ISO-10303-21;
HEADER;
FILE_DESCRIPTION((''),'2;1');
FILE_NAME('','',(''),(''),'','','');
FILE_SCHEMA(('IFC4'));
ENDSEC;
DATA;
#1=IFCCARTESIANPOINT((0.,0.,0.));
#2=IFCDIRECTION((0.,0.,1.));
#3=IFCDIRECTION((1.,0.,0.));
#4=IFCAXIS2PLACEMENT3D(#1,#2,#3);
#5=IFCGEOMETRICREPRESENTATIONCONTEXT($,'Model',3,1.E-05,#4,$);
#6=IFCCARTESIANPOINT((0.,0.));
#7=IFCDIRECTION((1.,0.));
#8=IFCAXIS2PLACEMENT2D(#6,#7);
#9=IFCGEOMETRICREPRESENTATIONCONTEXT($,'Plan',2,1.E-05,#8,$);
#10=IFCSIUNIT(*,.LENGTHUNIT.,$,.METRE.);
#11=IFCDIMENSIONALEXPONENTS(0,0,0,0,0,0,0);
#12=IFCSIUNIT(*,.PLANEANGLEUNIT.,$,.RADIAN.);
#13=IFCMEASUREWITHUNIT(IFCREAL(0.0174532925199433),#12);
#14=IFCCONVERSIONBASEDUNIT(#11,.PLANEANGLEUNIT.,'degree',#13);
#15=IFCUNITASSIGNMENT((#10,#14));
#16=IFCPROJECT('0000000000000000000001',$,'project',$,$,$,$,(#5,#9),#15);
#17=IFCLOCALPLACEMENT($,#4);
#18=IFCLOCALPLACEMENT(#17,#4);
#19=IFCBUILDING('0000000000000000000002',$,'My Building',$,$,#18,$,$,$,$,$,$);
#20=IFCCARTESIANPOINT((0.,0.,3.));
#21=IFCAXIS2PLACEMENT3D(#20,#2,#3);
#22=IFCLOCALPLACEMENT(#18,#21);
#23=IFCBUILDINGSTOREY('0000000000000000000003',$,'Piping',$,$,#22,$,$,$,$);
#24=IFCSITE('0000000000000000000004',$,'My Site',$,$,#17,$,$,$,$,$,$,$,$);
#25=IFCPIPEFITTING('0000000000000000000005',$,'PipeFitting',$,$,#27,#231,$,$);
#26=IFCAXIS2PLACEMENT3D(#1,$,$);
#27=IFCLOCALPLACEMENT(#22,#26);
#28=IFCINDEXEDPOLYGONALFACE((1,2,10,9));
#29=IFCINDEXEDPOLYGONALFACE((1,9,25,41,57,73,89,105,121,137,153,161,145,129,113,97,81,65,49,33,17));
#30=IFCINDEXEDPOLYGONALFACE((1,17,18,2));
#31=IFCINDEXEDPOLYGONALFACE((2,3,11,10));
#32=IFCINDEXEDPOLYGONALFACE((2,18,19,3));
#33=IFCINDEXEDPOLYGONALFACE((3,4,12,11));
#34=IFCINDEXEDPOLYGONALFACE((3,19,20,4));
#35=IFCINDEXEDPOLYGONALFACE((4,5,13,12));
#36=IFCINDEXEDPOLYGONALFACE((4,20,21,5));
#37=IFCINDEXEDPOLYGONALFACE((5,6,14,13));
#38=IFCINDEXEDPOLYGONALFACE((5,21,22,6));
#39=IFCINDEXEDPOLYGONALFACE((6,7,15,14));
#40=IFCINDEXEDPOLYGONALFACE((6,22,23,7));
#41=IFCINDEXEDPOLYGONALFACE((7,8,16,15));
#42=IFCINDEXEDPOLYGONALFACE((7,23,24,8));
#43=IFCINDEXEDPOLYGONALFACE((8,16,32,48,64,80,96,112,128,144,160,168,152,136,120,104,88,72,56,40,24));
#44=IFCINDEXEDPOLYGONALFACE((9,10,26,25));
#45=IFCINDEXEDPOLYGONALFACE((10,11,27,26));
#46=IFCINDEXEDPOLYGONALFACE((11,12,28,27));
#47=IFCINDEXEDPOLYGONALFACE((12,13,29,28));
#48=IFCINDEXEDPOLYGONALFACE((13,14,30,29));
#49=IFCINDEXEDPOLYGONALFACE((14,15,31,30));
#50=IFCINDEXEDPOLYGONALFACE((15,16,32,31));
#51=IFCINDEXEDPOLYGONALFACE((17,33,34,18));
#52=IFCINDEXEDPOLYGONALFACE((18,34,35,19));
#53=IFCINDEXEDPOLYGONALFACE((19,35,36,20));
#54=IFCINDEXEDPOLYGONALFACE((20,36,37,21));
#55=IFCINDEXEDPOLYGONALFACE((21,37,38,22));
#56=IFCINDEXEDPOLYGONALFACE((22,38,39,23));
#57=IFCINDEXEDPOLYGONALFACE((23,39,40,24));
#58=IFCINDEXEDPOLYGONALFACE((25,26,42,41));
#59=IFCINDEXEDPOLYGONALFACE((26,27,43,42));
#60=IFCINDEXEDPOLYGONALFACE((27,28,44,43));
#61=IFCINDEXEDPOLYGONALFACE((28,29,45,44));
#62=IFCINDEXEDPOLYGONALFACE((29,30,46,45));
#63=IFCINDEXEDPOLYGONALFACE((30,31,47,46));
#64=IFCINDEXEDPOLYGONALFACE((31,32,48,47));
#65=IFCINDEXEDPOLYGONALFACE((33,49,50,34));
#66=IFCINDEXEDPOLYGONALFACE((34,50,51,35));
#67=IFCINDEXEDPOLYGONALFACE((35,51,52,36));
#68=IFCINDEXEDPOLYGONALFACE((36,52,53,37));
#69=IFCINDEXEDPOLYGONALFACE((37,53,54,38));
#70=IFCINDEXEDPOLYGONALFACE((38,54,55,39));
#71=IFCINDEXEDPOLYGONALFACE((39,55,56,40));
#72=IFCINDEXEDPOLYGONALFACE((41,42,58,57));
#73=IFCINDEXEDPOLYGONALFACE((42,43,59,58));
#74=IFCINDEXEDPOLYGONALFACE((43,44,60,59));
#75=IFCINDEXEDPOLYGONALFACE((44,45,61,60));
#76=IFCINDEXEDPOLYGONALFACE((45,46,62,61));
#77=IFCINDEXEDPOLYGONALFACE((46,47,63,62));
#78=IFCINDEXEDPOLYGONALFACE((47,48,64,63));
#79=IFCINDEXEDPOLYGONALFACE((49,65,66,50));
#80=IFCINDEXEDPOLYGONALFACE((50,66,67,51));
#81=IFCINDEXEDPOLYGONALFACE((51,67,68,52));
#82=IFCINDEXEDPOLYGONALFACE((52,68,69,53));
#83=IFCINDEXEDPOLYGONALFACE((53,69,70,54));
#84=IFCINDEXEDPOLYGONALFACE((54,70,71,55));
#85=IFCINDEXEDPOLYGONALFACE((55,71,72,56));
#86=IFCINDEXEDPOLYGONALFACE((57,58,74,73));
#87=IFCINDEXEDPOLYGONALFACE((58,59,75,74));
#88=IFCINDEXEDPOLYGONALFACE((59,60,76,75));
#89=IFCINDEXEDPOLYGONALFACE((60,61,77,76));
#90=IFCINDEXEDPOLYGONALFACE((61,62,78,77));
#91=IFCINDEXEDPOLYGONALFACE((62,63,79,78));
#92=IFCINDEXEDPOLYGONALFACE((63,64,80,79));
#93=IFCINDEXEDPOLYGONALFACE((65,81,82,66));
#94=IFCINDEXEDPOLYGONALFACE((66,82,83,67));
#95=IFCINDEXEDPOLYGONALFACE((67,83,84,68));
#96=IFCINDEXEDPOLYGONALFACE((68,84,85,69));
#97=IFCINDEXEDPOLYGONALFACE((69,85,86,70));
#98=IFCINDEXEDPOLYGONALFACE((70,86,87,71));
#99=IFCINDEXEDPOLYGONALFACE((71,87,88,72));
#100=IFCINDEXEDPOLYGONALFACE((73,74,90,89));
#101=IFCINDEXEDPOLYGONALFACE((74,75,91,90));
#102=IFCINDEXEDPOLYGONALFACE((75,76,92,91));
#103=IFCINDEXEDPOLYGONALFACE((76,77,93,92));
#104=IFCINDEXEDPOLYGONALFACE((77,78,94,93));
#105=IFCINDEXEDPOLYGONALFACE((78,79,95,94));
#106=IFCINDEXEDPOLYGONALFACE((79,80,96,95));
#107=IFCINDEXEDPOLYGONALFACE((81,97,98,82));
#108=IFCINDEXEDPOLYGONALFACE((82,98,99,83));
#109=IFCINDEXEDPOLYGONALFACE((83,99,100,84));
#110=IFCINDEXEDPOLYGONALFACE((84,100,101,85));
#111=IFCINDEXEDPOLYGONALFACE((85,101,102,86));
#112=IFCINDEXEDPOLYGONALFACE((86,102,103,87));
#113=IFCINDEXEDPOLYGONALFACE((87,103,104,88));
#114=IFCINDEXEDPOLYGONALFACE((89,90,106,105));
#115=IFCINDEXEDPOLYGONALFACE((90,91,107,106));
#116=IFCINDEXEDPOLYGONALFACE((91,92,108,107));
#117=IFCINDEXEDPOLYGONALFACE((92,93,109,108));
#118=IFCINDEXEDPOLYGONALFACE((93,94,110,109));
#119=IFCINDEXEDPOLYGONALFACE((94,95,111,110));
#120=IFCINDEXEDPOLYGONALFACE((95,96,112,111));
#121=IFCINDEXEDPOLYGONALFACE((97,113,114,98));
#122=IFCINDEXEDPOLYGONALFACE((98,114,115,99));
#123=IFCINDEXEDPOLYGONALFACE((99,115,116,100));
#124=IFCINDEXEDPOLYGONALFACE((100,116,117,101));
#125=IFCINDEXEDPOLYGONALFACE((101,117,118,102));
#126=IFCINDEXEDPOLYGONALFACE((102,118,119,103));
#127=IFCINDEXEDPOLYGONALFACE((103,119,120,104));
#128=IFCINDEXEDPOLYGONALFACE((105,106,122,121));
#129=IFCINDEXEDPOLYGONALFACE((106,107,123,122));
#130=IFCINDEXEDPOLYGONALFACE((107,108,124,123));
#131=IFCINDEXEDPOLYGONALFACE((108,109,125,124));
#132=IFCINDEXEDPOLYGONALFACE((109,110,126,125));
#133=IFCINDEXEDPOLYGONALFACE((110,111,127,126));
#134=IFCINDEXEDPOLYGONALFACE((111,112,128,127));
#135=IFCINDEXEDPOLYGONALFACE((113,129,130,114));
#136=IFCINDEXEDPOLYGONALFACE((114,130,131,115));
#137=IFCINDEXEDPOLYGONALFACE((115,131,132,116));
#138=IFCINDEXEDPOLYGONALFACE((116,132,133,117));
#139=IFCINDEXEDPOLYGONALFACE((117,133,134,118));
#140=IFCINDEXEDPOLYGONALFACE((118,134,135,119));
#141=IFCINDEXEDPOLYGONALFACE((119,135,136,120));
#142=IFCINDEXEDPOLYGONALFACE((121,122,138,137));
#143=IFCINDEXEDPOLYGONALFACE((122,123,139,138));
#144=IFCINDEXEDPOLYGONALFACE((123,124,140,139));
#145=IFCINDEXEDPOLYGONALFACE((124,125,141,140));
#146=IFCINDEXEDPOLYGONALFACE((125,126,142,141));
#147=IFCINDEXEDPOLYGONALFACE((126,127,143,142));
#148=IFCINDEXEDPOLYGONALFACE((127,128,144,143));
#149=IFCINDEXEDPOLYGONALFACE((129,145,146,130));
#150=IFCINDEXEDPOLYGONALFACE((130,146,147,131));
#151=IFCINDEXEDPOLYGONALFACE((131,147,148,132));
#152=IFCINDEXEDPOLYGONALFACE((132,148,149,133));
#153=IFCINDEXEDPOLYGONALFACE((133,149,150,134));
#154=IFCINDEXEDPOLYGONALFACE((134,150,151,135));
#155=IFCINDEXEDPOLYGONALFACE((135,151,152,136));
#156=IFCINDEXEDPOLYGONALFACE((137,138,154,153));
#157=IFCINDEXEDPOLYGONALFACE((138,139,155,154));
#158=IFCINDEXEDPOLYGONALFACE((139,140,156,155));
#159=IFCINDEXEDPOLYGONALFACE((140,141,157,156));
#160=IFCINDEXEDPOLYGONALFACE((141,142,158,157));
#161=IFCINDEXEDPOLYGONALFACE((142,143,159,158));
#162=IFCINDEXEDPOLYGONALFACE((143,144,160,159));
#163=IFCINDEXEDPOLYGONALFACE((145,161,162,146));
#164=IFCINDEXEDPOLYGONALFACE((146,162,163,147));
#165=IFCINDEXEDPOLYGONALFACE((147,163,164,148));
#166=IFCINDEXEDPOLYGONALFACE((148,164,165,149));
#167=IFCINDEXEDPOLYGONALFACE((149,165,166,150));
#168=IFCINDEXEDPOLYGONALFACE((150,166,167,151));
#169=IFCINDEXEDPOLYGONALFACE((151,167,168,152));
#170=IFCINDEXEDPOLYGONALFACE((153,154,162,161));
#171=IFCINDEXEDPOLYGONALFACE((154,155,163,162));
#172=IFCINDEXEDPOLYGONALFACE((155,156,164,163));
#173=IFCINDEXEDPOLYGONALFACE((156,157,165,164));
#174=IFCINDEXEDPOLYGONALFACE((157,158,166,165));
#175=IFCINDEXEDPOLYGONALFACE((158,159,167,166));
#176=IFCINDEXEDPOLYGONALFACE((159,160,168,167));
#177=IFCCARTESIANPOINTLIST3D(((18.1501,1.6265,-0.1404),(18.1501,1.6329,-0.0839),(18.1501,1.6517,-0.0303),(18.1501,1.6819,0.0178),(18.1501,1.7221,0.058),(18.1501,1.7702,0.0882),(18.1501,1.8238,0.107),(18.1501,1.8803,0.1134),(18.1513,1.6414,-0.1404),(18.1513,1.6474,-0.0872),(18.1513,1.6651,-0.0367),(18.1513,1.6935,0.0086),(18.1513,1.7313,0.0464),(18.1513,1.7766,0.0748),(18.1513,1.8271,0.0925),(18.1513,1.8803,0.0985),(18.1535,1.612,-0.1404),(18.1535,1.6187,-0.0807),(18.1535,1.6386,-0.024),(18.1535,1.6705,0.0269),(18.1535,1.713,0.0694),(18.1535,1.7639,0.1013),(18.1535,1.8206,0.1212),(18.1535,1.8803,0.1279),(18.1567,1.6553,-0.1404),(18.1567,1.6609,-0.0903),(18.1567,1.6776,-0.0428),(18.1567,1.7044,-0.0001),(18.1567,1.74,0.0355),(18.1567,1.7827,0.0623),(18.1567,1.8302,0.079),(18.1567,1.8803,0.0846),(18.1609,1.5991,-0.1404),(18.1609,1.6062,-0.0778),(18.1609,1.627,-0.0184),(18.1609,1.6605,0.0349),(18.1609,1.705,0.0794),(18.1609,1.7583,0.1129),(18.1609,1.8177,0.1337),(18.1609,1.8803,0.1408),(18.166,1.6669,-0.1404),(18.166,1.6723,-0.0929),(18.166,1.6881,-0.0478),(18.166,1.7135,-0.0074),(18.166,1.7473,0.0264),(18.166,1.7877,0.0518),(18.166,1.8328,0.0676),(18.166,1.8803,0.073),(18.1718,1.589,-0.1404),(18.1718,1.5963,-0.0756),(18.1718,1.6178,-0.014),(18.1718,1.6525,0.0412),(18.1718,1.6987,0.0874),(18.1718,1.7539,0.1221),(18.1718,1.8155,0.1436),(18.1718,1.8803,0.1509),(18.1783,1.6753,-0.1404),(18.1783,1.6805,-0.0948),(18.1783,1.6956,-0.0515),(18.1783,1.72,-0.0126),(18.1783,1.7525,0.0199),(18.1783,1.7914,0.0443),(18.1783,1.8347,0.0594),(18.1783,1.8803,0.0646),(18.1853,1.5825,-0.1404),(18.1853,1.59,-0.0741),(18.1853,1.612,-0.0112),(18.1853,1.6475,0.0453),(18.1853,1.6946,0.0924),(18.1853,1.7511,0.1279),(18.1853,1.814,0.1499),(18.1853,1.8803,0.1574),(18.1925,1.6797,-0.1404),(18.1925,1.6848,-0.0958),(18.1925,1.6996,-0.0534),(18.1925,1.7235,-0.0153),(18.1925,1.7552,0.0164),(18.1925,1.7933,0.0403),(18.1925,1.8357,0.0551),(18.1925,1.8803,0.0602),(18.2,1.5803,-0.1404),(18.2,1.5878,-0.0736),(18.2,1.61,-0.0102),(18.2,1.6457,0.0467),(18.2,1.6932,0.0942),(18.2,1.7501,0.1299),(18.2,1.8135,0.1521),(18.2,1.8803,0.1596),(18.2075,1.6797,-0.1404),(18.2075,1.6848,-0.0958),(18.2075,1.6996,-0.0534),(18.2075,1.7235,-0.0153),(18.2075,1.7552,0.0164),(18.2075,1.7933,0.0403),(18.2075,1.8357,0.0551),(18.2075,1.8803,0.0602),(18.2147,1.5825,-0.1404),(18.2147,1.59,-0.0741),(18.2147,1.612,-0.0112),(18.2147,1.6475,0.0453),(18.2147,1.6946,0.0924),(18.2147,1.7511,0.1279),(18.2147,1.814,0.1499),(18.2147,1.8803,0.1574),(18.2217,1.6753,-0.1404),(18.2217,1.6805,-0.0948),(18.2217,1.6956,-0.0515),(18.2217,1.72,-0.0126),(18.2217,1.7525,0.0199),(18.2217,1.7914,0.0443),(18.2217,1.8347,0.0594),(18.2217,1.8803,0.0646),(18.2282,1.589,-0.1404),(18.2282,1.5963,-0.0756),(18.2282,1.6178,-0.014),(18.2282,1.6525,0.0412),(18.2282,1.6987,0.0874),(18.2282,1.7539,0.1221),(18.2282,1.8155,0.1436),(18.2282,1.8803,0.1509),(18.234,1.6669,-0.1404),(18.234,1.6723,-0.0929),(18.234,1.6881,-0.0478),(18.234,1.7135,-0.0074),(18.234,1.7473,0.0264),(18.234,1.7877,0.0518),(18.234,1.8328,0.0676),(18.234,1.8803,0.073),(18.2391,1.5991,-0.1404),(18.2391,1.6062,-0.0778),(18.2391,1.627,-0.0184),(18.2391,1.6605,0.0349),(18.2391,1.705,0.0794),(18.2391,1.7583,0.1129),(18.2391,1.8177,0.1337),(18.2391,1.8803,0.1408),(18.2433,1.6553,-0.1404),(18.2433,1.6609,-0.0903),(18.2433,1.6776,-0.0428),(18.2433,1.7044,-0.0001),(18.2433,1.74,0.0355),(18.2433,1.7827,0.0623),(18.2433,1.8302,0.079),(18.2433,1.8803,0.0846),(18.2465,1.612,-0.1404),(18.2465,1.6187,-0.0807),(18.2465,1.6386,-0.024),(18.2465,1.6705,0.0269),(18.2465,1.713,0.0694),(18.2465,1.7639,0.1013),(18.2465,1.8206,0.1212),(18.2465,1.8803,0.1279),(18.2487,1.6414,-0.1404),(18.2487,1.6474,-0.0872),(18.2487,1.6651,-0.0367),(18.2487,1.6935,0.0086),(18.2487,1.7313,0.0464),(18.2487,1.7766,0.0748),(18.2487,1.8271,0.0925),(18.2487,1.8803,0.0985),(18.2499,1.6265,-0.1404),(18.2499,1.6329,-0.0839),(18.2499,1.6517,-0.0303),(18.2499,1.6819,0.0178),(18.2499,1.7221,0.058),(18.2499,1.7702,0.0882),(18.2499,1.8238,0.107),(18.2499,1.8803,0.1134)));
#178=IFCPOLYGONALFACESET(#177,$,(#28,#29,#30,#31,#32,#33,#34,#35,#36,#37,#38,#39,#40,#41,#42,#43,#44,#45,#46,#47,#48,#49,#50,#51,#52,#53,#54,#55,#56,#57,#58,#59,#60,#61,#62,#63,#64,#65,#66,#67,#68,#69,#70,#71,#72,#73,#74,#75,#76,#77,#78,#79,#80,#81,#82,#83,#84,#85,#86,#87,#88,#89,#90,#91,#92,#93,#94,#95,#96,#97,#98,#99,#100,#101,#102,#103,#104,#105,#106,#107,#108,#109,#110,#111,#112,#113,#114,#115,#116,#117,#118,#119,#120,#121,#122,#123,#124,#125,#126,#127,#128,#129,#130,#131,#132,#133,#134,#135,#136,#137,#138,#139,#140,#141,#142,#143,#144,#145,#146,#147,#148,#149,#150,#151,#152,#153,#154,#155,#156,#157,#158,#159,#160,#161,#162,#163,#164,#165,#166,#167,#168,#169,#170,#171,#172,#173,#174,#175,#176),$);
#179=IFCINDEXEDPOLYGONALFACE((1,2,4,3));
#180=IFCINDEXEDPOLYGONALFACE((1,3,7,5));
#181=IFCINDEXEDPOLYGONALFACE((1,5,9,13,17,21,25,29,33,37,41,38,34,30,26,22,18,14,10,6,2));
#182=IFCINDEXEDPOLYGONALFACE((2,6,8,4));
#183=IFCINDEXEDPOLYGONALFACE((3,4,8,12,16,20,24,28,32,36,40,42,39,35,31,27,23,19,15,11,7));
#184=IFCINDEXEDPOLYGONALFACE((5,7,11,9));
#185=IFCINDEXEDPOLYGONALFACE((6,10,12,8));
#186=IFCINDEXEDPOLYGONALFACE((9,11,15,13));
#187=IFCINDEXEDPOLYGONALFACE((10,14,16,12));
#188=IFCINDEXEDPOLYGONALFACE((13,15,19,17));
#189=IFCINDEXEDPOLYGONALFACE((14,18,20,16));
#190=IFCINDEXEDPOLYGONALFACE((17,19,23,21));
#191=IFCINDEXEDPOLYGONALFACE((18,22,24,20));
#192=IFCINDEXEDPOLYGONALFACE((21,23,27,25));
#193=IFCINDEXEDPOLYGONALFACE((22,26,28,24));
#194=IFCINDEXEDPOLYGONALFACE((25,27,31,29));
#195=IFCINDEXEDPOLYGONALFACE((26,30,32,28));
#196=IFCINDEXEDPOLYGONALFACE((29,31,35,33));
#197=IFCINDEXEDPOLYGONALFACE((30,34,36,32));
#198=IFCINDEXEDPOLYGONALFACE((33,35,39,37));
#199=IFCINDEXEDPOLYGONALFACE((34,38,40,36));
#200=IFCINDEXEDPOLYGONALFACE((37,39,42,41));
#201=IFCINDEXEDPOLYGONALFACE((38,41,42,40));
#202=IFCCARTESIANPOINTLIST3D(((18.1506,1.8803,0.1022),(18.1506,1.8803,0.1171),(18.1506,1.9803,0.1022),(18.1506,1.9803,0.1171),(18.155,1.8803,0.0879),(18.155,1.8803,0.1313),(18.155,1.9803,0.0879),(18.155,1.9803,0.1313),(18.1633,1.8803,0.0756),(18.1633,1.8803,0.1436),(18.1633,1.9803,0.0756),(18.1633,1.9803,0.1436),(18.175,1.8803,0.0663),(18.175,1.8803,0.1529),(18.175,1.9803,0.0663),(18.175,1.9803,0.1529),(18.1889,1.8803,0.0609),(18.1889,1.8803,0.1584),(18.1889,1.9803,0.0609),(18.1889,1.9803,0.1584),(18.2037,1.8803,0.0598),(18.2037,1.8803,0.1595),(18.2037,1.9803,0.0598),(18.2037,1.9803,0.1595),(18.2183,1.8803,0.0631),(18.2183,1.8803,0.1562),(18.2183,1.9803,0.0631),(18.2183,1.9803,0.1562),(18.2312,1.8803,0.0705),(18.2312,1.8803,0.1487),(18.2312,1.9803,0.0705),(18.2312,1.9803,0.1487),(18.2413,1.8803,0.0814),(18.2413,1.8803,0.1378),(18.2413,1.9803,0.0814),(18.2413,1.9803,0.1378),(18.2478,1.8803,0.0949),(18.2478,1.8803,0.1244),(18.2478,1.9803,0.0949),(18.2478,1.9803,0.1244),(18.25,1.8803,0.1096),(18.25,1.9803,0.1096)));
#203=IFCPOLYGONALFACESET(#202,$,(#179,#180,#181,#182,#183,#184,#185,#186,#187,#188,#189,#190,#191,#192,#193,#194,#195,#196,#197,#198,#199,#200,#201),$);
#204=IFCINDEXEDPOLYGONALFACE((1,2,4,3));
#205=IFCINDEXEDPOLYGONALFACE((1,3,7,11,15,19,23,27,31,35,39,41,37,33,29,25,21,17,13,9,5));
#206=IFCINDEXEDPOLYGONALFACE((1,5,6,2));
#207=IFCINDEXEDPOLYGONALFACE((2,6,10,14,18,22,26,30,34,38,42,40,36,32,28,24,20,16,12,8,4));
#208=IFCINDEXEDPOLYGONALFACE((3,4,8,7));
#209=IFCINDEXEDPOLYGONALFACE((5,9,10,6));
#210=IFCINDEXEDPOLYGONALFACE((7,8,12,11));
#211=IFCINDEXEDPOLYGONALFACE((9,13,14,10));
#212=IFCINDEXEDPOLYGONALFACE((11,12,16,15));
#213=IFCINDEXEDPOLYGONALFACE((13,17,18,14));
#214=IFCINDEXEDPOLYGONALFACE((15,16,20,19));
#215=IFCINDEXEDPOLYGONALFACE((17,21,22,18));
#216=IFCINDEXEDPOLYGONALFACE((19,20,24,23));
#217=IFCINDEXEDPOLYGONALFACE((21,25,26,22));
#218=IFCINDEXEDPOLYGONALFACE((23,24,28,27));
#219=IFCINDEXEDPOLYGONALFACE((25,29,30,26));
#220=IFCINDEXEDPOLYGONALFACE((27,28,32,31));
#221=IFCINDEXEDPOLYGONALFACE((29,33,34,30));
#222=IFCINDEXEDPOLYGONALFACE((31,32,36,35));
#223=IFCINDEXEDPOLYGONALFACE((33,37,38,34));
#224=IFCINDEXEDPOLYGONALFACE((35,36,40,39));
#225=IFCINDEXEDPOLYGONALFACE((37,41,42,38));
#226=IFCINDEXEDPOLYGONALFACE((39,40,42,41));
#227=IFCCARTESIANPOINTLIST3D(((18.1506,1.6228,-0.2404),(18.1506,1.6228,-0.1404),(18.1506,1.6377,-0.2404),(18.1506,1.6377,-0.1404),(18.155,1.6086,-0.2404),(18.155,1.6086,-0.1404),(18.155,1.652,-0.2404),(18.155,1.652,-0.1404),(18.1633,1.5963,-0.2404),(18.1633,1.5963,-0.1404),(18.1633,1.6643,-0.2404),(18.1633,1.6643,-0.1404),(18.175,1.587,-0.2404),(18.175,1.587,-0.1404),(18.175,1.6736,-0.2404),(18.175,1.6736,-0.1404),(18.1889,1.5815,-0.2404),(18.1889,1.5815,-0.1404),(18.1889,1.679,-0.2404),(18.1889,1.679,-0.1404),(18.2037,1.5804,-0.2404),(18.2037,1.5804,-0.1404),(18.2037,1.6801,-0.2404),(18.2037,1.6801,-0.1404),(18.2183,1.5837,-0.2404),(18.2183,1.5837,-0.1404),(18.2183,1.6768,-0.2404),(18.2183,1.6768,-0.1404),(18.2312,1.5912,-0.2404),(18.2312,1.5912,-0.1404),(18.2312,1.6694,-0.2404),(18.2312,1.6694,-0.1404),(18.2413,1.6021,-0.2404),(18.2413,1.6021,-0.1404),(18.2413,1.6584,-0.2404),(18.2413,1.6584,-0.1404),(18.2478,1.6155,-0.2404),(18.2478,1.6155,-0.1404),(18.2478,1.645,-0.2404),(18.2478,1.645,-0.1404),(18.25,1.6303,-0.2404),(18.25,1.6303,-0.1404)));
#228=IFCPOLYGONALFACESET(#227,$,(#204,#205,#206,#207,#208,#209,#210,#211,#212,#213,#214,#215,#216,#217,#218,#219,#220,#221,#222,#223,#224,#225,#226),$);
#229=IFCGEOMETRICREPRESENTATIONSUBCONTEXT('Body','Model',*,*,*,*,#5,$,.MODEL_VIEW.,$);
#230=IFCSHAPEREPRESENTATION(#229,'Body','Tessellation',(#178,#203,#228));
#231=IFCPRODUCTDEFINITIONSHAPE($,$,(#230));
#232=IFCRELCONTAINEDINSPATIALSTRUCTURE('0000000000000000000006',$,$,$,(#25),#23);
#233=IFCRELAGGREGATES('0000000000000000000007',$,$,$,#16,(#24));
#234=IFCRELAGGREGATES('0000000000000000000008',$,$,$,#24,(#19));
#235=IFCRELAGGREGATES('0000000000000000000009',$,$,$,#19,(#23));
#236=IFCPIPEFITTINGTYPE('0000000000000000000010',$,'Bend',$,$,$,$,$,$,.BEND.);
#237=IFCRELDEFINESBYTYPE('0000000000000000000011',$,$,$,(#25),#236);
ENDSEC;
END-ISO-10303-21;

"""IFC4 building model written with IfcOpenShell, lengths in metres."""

from ifc_helpers import new_model, entity, si_unit, converted_unit, frame, origin_with_axes, origin_2d_with_axis, place, context, subcontext, project, spatial, circle, extrude, source, transform, mapped, type_object, type_shapes, element, save


model = new_model("IFC4")

# Units and contexts
model_context = context("Model", 3, precision=1e-05, world=origin_with_axes())
plan_context = context("Plan", 2, precision=1e-05, world=origin_2d_with_axis())
body_context = subcontext(model_context, "Body", "Model", "MODEL_VIEW")
ifc_project = project(units=[si_unit("LENGTHUNIT", "METRE"), converted_unit("PLANEANGLEUNIT", "degree", entity("IfcReal", 0.0174532925199433), si_unit("PLANEANGLEUNIT", "RADIAN"), dimensions=[0, 0, 0, 0, 0, 0, 0])], contexts=[model_context, plan_context])

# Site, building, storey
site_placement = place(None, origin_with_axes())
site = spatial("IfcSite", under=ifc_project, at=site_placement, Name="My Site")
building_placement = place(site_placement, origin_with_axes())
building = spatial("IfcBuilding", under=site, at=building_placement, Name="My Building")
storey_placement = place(building_placement, frame((0.0, 0.0, 3.0), z_axis=(0.0, 0.0, 1.0), x_axis=(1.0, 0.0, 0.0)))
storey = spatial("IfcBuildingStorey", under=building, at=storey_placement, Name="Piping")

# Pipe fitting
pipe_fitting_type_1 = type_object("IfcPipeFittingType", Name="Bend", PredefinedType="BEND")
shared_shape_1 = source(origin_with_axes(), body_context, "Body", "SolidModel", [
    entity("IfcSweptDiskSolid", entity("IfcIndexedPolyCurve", entity("IfcCartesianPointList3D", [[0.0, 0.0, 0.1], [0.0, -0.0732, 0.2768], [0.0, -0.25, 0.35]]), [entity("IfcArcIndex", [1, 2, 3])]), 0.05),
    extrude(circle(Radius=0.05), origin_with_axes(), (0.0, 0.0, 1.0), 0.1),
    extrude(circle(Radius=0.05), frame((0.0, -0.25, 0.35), z_axis=(0.0, -1.0, -0.000007), x_axis=(1.0, 0.0, 0.0)), (0.0, 0.0, 1.0), 0.1),
])
type_shapes(pipe_fitting_type_1, [shared_shape_1])
pipe_fitting_1_placement = place(storey_placement, frame((18.2, 1.9803, 0.1096), z_axis=(0.0, -1.0, 0.000007), x_axis=(1.0, 0.0, 0.0)))
element("IfcPipeFitting", 1, at=pipe_fitting_1_placement, inside=storey, type_object=pipe_fitting_type_1, Name="PipeFitting", context=body_context, shape_type="MappedRepresentation", body=[
    mapped(shared_shape_1, transform((0.0, 0.0, 0.0), x_axis=(1.0, 0.0, 0.0), y_axis=(0.0, 1.0, 0.0), z_axis=(0.0, 0.0, 1.0), scale=1.0)),
])

save(model, "model.ifc")
